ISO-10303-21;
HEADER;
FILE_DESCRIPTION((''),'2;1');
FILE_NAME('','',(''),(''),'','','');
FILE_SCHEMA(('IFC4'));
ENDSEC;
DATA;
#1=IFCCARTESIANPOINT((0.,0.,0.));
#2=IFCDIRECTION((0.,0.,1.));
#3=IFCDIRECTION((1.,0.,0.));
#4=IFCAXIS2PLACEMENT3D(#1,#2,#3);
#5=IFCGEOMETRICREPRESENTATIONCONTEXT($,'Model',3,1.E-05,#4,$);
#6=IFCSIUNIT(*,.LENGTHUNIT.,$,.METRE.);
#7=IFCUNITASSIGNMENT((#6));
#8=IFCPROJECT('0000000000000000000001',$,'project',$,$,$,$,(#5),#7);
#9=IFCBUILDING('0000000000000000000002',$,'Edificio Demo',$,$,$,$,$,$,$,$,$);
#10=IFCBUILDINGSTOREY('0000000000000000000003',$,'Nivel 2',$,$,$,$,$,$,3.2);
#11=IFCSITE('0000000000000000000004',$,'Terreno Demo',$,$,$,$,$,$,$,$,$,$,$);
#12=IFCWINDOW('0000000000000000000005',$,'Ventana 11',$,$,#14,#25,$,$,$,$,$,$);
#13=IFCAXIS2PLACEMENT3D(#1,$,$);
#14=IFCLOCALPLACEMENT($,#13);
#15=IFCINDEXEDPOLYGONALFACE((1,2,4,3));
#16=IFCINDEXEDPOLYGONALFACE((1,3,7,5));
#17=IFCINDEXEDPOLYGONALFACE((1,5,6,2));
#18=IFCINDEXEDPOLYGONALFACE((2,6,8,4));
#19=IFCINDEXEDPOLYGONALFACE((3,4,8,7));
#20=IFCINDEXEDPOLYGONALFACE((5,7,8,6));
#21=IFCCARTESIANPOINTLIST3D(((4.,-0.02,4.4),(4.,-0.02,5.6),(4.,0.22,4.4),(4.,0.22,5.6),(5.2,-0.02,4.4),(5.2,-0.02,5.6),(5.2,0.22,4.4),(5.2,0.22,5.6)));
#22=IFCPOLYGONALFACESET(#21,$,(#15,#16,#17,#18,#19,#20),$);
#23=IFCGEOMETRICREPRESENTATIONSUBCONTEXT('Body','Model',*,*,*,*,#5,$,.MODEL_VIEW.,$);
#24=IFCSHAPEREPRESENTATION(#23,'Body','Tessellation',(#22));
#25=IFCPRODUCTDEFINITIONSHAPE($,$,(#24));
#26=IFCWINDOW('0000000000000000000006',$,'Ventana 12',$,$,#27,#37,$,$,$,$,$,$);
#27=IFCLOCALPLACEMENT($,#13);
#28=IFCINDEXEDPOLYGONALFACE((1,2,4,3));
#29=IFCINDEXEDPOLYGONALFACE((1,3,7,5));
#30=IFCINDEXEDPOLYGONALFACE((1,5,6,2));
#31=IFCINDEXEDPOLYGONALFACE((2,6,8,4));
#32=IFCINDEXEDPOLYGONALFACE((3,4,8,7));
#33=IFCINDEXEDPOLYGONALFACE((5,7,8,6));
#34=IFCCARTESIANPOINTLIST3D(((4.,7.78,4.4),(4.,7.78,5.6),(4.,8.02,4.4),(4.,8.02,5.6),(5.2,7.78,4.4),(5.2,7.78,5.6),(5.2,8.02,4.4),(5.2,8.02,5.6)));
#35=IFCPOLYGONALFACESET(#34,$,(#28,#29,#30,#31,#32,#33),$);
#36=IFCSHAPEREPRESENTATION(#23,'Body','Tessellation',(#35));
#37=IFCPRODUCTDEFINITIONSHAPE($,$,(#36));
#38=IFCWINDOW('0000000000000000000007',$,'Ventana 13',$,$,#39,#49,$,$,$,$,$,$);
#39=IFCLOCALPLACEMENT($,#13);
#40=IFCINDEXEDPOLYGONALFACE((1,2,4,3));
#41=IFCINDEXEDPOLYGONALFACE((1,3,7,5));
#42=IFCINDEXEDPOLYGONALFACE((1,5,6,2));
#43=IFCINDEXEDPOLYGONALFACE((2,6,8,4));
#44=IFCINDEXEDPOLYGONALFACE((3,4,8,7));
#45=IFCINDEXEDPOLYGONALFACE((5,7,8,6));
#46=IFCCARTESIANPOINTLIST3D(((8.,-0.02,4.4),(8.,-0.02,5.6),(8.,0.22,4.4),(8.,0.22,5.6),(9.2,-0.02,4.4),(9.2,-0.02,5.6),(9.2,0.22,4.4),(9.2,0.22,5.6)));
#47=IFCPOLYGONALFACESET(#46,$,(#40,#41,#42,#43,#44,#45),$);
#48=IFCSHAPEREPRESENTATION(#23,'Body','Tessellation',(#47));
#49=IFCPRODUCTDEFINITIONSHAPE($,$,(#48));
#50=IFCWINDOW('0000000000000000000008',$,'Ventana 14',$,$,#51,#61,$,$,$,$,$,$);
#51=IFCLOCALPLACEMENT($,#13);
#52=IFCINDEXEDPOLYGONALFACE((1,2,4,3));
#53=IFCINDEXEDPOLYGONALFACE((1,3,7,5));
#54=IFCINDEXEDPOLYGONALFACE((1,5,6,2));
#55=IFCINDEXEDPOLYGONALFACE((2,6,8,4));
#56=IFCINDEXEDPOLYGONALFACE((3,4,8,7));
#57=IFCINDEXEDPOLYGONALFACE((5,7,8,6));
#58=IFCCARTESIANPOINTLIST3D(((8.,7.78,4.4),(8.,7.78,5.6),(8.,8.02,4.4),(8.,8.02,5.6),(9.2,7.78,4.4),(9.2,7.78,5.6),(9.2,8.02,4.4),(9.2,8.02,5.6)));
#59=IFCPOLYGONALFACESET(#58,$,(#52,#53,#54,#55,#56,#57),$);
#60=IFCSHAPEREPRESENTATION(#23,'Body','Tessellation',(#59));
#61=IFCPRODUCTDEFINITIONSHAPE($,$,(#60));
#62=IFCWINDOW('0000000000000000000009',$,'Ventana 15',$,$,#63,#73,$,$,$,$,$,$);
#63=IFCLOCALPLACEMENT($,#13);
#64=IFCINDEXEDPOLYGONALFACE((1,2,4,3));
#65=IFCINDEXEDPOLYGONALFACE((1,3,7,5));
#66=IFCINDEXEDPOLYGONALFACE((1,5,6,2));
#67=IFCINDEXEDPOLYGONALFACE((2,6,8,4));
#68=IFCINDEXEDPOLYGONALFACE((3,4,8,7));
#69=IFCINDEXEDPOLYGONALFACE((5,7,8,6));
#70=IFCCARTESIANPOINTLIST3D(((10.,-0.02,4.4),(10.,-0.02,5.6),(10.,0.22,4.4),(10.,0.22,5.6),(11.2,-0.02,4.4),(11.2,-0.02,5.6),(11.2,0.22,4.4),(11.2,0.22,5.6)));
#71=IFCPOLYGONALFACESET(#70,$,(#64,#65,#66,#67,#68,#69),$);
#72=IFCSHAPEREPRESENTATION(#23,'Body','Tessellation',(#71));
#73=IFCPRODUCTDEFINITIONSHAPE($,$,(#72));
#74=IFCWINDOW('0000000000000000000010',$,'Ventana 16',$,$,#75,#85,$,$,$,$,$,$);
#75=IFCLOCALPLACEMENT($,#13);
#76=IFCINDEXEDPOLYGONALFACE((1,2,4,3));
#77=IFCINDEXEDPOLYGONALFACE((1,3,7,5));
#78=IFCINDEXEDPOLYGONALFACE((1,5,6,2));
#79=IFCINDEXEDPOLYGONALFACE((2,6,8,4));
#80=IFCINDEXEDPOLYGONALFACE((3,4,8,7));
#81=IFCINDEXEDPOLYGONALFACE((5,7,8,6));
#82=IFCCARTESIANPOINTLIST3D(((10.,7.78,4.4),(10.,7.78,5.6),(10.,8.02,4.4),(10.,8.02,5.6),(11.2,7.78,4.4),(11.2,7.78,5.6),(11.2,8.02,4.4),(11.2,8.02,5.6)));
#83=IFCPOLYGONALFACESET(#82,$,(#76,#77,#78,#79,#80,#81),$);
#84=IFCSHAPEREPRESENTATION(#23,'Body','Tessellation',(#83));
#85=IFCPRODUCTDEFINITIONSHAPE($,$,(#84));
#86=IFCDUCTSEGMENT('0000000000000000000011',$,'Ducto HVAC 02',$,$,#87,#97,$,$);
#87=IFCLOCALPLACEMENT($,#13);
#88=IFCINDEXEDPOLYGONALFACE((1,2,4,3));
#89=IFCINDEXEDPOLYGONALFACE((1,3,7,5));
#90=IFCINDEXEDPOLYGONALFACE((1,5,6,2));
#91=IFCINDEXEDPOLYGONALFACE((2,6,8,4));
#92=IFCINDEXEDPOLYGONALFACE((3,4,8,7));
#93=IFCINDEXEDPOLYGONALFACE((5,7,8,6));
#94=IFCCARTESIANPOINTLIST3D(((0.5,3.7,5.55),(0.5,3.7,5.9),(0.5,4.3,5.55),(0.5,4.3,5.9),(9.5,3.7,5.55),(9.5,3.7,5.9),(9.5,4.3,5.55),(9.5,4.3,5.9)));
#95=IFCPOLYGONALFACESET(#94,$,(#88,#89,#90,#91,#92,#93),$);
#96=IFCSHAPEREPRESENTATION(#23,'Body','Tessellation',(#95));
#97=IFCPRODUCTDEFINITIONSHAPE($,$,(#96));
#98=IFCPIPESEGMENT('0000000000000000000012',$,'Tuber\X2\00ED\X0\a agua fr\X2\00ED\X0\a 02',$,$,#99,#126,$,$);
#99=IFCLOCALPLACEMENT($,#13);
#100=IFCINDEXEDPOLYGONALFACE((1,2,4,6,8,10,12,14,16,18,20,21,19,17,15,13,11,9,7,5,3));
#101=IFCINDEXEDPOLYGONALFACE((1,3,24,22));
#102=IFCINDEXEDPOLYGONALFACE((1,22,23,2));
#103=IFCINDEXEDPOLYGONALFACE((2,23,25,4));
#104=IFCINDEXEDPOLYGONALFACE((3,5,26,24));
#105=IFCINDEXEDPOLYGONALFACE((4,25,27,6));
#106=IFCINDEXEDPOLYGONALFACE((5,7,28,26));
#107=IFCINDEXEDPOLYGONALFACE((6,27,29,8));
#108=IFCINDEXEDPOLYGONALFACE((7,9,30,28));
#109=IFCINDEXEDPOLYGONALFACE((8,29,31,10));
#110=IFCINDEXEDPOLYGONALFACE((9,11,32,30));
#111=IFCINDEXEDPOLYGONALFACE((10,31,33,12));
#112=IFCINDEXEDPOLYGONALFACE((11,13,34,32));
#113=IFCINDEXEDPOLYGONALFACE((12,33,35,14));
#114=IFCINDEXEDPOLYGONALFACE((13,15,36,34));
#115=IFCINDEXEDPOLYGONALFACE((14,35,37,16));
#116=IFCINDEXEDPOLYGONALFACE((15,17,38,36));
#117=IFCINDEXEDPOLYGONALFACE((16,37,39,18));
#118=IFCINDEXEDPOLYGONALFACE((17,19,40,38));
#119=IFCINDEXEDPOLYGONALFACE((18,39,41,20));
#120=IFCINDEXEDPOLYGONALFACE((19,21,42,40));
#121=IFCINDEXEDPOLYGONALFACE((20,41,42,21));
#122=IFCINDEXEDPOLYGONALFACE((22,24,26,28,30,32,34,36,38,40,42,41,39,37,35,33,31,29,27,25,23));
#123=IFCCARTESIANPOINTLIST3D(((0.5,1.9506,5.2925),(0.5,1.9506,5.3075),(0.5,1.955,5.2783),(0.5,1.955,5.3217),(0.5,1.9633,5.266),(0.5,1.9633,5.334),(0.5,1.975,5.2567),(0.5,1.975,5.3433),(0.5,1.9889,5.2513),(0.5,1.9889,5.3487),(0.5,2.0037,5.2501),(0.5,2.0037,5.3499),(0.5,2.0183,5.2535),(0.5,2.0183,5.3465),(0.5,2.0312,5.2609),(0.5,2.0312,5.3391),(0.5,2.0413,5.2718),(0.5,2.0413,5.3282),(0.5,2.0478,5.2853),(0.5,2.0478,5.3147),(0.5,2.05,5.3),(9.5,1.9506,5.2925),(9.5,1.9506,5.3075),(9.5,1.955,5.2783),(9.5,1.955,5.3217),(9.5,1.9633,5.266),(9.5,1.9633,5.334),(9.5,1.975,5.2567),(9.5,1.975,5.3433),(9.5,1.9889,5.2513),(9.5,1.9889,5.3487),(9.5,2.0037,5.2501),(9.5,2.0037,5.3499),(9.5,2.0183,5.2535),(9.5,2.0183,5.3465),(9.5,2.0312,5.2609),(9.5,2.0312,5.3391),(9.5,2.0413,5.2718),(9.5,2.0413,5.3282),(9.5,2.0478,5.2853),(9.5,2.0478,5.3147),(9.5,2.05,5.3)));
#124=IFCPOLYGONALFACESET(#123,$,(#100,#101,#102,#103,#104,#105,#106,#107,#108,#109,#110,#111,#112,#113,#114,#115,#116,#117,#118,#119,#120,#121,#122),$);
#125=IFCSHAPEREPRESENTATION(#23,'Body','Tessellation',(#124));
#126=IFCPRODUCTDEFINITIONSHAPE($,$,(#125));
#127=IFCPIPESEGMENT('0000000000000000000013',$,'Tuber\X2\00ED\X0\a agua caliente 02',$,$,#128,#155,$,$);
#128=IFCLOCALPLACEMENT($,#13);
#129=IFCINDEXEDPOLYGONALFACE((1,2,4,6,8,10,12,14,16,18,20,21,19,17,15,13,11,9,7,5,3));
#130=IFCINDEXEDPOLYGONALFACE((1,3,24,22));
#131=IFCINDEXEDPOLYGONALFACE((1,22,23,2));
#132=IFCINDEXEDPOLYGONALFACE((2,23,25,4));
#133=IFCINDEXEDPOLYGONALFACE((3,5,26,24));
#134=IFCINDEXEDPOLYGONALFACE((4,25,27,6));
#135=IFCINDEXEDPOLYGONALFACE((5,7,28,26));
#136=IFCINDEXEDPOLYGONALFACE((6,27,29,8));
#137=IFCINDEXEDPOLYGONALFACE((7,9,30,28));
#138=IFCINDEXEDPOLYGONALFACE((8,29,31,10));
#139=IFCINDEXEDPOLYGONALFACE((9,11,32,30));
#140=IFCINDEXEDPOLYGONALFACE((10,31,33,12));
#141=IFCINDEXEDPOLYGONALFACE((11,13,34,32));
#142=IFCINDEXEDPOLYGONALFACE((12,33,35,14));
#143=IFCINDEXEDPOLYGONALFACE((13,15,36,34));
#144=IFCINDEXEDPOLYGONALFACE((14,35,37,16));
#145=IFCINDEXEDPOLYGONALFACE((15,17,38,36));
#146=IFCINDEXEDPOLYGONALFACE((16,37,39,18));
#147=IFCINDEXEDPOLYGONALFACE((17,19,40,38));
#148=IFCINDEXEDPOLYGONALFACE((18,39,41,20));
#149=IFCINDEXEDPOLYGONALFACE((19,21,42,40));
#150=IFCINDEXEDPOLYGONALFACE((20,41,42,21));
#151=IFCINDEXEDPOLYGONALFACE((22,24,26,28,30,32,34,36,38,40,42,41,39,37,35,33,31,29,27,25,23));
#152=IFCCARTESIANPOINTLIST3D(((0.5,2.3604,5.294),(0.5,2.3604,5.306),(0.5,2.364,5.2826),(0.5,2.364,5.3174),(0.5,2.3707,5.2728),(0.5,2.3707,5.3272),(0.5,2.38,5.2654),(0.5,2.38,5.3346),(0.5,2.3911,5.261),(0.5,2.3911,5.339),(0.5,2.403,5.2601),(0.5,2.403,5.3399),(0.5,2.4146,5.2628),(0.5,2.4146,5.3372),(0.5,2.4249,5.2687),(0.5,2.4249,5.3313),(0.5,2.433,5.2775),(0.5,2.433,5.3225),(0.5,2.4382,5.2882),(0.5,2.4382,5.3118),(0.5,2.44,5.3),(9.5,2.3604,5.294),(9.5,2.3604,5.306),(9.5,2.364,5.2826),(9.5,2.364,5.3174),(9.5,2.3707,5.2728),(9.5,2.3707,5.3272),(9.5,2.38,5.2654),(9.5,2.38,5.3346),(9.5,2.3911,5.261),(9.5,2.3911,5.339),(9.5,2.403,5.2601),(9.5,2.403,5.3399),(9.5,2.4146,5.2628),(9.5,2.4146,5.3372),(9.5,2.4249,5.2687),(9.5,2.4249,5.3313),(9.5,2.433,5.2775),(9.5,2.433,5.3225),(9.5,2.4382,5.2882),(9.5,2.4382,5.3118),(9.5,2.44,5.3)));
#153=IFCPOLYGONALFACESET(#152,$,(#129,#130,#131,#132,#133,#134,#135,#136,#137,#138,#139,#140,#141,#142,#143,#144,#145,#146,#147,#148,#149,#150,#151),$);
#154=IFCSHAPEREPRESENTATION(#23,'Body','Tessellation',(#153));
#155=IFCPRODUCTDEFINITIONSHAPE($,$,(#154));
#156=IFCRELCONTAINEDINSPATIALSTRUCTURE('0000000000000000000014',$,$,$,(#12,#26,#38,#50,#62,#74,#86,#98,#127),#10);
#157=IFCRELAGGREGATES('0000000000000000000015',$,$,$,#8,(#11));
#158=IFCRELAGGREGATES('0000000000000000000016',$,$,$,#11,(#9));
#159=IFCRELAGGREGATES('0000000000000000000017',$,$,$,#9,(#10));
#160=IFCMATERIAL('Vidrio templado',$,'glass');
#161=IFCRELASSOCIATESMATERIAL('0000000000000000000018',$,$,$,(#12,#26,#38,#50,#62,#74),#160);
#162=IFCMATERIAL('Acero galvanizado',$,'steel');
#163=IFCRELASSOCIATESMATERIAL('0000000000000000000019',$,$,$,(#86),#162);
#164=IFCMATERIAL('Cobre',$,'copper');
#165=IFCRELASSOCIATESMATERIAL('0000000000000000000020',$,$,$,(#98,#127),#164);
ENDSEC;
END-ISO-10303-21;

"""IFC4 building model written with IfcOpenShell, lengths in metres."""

from ifc_helpers import new_model, si_unit, frame, frame_2d, origin_with_axes, place, context, subcontext, project, spatial, rectangle, circle, extrude, material, element, save


model = new_model("IFC4")

# Units and contexts
model_context = context("Model", 3, precision=1e-05, world=origin_with_axes())
body_context = subcontext(model_context, "Body", "Model", "MODEL_VIEW")
ifc_project = project(units=[si_unit("LENGTHUNIT", "METRE")], contexts=[model_context])

# Site, building, storey
site = spatial("IfcSite", under=ifc_project, Name="Terreno Demo")
building = spatial("IfcBuilding", under=site, Name="Edificio Demo")
storey = spatial("IfcBuildingStorey", under=building, Name="Nivel 2", Elevation=3.2)

# Windows
ifc_material_1 = material(Name="Vidrio templado", Category="glass")
for number, where, z_axis, x_axis, name in (
    (1, (4.0, -0.02, 4.4), (0.0, 0.0, 1.0), (1.0, 0.0, 0.0), "Ventana 11"),
    (2, (4.0, 7.78, 4.4), (0.0, 0.0, 1.0), (1.0, 0.0, 0.0), "Ventana 12"),
    (3, (8.0, -0.02, 4.4), (0.0, 0.0, 1.0), (1.0, 0.0, 0.0), "Ventana 13"),
    (4, (8.0, 7.78, 4.4), (0.0, 0.0, 1.0), (1.0, 0.0, 0.0), "Ventana 14"),
    (5, (10.0, -0.02, 4.4), (0.0, 0.0, 1.0), (1.0, 0.0, 0.0), "Ventana 15"),
    (6, (10.0, 7.78, 4.4), (0.0, 0.0, 1.0), (1.0, 0.0, 0.0), "Ventana 16"),
):
    element("IfcWindow", number, at=place(None, frame(where, z_axis=z_axis, x_axis=x_axis)), inside=storey, material=ifc_material_1, Name=name, context=body_context, shape_type="SweptSolid", body=[
        extrude(rectangle(XDim=1.2, YDim=0.24, at=frame_2d((0.6, 0.12))), origin_with_axes(), (0.0, 0.0, 1.0), 1.2),
    ])

# Duct segment
ifc_material_2 = material(Name="Acero galvanizado", Category="steel")
duct_segment_placement = place(None, frame((0.5, 3.7, 5.55), z_axis=(0.0, 0.0, 1.0), x_axis=(1.0, 0.0, 0.0)))
element("IfcDuctSegment", 7, at=duct_segment_placement, inside=storey, material=ifc_material_2, Name="Ducto HVAC 02", context=body_context, shape_type="SweptSolid", body=[
    extrude(rectangle(XDim=9.0, YDim=0.6, at=frame_2d((4.5, 0.3))), origin_with_axes(), (0.0, 0.0, 1.0), 0.35),
])

# Pipe segments
ifc_material_3 = material(Name="Cobre", Category="copper")
pipe_segment_1_placement = place(None, frame((0.5, 2.0, 5.3), z_axis=(0.0, 0.0, 1.0), x_axis=(1.0, 0.0, 0.0)))
element("IfcPipeSegment", 8, at=pipe_segment_1_placement, inside=storey, material=ifc_material_3, Name="Tubería agua fría 02", context=body_context, shape_type="SweptSolid", body=[
    extrude(circle(Radius=0.05), frame((0.0, 0.0, 0.0), z_axis=(1.0, 0.0, 0.0), x_axis=(0.0, 1.0, 0.0)), (0.0, 0.0, 1.0), 9.0),
])
pipe_segment_2_placement = place(None, frame((0.5, 2.4, 5.3), z_axis=(0.0, 0.0, 1.0), x_axis=(1.0, 0.0, 0.0)))
element("IfcPipeSegment", 9, at=pipe_segment_2_placement, inside=storey, material=ifc_material_3, Name="Tubería agua caliente 02", context=body_context, shape_type="SweptSolid", body=[
    extrude(circle(Radius=0.04), frame((0.0, 0.0, 0.0), z_axis=(1.0, 0.0, 0.0), x_axis=(0.0, 1.0, 0.0)), (0.0, 0.0, 1.0), 9.0),
])

save(model, "model.ifc")
